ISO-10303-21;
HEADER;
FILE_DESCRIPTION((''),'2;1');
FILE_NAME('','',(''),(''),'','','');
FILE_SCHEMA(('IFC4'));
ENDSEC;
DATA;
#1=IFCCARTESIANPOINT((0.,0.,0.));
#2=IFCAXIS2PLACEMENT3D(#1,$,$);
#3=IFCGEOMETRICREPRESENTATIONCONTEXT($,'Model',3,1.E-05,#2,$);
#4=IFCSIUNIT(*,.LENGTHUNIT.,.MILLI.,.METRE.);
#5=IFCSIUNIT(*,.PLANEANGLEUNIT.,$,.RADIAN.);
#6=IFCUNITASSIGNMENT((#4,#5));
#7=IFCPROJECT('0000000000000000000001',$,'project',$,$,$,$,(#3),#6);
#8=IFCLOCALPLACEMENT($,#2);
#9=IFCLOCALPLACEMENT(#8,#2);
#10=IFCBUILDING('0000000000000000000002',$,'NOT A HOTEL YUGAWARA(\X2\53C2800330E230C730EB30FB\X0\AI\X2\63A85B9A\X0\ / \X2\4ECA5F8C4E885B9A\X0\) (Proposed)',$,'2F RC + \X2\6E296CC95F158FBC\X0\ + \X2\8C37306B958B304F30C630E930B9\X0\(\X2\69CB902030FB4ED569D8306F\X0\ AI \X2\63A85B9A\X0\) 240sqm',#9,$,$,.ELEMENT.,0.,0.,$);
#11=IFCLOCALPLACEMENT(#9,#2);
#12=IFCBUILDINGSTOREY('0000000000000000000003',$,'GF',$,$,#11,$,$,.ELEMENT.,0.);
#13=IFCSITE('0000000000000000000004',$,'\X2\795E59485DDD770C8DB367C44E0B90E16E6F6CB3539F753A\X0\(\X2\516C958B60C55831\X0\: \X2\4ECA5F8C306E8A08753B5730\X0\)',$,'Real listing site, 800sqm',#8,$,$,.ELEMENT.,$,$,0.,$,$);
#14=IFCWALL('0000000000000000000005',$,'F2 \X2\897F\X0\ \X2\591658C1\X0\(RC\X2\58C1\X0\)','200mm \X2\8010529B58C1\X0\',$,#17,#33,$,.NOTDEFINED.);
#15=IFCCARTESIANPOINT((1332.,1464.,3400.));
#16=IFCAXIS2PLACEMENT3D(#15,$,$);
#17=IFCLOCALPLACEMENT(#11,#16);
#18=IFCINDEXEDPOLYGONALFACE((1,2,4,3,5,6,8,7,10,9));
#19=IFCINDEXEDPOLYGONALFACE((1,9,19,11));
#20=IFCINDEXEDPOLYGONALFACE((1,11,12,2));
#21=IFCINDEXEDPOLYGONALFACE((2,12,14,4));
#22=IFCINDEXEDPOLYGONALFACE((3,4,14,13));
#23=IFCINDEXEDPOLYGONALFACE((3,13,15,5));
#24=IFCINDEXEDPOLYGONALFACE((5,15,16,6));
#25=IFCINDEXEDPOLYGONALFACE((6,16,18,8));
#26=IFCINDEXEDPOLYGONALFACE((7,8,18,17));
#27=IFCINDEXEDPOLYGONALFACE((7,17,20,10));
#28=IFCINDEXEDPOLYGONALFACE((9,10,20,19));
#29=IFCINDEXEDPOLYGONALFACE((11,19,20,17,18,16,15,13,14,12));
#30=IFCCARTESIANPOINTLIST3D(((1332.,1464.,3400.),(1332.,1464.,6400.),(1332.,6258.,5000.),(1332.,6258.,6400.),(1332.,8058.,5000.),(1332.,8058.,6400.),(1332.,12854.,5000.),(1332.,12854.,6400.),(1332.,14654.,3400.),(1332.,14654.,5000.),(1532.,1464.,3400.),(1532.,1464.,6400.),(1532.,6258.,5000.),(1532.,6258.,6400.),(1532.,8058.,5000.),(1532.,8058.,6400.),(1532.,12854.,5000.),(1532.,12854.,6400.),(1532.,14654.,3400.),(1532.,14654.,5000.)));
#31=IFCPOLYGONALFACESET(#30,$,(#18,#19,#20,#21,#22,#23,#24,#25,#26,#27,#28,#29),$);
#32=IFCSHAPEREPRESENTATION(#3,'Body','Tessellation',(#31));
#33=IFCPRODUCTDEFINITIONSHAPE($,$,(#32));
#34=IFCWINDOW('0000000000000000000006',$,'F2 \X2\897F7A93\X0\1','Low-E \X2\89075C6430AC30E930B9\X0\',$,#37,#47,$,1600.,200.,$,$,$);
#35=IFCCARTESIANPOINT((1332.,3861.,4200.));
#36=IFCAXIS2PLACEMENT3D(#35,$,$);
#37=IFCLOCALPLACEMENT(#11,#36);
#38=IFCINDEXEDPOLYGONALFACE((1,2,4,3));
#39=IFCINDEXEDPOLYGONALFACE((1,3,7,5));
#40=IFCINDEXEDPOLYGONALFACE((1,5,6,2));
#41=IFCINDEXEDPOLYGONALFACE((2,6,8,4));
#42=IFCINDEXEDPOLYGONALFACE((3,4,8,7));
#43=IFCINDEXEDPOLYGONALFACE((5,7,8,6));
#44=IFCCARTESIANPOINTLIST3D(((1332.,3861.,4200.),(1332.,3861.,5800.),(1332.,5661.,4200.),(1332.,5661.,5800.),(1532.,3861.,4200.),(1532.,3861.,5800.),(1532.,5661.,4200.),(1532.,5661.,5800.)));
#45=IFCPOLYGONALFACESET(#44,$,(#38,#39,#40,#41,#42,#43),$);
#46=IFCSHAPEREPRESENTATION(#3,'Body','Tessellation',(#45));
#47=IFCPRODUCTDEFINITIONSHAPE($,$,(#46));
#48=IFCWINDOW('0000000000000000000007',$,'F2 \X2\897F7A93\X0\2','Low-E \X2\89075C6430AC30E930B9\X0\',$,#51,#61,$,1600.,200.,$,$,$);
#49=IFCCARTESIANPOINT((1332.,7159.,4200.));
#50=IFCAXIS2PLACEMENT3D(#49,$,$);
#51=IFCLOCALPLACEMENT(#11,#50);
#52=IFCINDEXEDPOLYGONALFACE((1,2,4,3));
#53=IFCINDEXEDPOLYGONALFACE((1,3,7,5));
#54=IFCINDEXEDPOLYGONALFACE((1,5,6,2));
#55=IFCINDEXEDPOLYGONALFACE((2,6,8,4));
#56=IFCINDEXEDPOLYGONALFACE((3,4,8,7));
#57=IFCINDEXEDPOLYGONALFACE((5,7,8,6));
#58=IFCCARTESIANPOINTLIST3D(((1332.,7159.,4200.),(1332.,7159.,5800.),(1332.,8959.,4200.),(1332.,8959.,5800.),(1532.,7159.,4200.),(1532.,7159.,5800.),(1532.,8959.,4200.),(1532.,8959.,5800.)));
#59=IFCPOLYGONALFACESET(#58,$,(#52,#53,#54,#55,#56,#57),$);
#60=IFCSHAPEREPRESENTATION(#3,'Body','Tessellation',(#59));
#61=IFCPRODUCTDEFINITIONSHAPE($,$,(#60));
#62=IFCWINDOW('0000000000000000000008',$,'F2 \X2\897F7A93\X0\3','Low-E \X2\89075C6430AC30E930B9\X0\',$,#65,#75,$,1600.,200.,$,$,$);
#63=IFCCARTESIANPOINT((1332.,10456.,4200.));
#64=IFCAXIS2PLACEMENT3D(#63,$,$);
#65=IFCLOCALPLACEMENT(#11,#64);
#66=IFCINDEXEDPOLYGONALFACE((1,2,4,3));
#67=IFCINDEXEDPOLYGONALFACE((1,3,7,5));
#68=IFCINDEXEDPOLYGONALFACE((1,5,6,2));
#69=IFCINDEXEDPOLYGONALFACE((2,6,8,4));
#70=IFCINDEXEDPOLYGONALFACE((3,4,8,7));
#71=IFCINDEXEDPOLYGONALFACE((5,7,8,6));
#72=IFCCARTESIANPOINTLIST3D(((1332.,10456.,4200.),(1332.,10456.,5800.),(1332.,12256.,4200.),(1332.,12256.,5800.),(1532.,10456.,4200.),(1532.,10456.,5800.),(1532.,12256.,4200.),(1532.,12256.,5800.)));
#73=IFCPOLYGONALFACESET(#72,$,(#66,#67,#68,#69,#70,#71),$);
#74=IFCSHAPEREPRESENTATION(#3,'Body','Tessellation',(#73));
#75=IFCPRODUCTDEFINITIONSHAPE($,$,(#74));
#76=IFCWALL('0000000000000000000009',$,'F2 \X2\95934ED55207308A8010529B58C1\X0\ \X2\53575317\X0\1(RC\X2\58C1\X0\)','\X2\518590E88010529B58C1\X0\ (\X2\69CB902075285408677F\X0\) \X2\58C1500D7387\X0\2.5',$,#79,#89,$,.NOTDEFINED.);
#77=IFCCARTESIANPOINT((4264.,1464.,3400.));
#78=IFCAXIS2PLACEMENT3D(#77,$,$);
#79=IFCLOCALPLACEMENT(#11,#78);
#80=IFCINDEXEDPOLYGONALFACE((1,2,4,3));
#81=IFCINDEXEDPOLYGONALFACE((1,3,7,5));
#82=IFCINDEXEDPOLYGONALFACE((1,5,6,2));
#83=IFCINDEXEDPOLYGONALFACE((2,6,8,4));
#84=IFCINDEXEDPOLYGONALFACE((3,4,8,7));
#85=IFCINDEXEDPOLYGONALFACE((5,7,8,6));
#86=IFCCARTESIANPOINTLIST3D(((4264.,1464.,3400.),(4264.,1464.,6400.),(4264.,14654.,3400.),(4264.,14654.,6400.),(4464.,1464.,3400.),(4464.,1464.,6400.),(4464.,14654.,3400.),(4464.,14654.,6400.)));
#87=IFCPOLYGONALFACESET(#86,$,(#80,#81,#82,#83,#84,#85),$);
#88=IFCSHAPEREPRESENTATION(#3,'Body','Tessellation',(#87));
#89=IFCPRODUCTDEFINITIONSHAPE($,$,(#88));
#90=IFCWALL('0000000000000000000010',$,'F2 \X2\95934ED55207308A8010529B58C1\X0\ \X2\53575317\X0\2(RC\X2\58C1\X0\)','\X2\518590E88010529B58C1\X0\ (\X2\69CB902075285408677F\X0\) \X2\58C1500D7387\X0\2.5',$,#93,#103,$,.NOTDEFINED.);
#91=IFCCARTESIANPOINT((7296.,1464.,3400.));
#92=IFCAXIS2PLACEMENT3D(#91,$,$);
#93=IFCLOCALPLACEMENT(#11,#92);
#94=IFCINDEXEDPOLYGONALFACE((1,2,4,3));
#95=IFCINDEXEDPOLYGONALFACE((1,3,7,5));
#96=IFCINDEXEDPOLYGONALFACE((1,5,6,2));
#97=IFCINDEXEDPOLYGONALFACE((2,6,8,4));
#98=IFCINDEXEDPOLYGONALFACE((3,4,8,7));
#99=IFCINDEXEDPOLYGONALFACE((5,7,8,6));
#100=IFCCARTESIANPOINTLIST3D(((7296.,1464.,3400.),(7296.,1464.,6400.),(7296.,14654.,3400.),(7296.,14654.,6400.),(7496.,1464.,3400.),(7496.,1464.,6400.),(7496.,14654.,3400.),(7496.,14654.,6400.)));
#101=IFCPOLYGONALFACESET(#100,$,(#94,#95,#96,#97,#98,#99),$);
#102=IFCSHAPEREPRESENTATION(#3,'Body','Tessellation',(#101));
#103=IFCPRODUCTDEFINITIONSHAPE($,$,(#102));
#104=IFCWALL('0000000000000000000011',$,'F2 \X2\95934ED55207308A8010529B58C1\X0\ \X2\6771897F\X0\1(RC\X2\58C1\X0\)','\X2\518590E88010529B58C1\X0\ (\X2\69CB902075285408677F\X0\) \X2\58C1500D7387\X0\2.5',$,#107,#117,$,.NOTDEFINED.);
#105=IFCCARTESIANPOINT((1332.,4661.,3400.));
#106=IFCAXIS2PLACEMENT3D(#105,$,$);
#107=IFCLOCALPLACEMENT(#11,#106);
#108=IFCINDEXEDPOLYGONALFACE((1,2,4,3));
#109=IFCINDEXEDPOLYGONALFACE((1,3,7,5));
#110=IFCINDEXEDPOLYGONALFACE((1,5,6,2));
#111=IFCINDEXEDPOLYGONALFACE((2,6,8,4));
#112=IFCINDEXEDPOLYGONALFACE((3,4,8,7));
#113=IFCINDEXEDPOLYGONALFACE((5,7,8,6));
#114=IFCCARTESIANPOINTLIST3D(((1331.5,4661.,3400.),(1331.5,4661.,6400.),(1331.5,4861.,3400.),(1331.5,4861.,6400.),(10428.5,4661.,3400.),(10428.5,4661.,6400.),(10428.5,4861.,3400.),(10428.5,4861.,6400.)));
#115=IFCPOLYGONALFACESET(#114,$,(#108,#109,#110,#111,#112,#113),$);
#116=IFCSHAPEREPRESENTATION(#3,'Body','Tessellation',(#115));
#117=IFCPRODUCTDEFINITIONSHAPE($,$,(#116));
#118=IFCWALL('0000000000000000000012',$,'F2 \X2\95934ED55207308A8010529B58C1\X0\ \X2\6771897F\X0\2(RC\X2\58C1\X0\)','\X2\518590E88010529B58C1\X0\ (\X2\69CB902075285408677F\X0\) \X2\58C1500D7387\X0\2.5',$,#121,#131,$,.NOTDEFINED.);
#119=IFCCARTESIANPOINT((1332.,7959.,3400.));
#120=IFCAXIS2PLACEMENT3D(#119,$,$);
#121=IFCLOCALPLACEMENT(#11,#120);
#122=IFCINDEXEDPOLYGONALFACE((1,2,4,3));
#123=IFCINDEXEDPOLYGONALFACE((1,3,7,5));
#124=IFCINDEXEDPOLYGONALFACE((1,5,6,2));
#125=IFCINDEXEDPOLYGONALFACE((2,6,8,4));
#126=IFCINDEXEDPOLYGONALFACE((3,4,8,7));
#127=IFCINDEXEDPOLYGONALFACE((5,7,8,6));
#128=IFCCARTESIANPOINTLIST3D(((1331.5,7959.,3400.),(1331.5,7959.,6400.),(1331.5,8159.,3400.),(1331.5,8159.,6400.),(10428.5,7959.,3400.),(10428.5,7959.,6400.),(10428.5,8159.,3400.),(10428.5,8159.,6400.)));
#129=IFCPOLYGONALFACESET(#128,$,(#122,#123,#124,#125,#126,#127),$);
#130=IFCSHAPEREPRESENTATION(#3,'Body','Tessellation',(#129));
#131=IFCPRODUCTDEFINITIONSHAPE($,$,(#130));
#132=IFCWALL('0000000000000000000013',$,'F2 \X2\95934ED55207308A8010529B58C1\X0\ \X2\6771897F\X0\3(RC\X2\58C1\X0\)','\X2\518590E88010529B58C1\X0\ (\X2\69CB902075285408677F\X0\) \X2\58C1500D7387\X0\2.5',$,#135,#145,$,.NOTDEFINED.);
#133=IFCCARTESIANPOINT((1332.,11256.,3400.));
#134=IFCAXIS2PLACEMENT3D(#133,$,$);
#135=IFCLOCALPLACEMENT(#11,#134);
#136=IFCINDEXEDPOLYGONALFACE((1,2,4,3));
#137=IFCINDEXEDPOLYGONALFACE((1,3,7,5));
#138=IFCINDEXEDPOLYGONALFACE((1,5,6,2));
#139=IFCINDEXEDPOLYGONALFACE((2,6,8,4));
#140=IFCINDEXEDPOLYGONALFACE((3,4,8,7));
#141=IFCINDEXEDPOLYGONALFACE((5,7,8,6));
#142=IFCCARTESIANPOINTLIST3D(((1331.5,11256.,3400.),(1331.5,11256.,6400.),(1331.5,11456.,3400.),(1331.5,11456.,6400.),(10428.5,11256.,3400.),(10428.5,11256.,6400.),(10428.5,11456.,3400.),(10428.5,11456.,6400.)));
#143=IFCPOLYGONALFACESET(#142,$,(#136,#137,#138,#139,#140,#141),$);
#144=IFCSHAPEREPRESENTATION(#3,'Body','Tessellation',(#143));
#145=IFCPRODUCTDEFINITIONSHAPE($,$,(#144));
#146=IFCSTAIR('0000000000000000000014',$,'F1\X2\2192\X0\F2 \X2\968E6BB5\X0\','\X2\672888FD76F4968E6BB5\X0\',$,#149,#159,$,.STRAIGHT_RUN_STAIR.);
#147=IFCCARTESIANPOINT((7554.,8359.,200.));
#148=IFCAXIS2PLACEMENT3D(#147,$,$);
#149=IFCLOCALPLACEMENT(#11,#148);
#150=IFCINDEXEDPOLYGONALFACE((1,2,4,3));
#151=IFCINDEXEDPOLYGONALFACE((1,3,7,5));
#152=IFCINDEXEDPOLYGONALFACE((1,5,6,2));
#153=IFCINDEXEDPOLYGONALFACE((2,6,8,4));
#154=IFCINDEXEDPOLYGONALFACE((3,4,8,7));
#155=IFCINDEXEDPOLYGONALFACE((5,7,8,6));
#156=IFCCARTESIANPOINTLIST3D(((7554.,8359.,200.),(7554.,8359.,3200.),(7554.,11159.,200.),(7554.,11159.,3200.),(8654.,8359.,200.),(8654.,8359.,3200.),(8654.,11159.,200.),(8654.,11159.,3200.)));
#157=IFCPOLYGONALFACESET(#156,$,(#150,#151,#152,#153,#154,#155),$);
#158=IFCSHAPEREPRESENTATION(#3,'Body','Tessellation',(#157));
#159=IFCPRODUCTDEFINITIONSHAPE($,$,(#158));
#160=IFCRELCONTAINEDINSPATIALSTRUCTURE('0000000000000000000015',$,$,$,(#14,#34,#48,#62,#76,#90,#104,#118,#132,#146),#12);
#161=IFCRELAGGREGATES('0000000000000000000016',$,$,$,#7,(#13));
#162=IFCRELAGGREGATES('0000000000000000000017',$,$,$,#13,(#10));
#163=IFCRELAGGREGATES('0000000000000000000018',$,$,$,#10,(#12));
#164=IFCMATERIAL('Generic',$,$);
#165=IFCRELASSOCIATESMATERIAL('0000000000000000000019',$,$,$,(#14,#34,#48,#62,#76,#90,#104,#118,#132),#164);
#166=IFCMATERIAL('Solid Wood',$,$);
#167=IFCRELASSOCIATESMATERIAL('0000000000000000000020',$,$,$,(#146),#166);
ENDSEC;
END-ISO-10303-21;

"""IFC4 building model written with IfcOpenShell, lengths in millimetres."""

from ifc_helpers import new_model, si_unit, frame, frame_2d, origin, place, context, project, spatial, rectangle, extrude, material, element, fill, save


model = new_model("IFC4")

# Units and contexts
model_context = context("Model", 3, precision=1e-05, world=origin())
ifc_project = project(units=[si_unit("LENGTHUNIT", "METRE", prefix="MILLI"), si_unit("PLANEANGLEUNIT", "RADIAN")], contexts=[model_context])

# Site, building, storey
site_placement = place(None, origin())
site = spatial("IfcSite", under=ifc_project, at=site_placement, Name="神奈川県足柄下郡湯河原町(公開情報: 今後の計画地)", ObjectType="Real listing site, 800sqm", CompositionType="ELEMENT", RefElevation=0.0)
building_placement = place(site_placement, origin())
building = spatial("IfcBuilding", under=site, at=building_placement, Name="NOT A HOTEL YUGAWARA(参考モデル・AI推定 / 今後予定) (Proposed)", ObjectType="2F RC + 温泉引込 + 谷に開くテラス(構造・仕様は AI 推定) 240sqm", CompositionType="ELEMENT", ElevationOfRefHeight=0.0, ElevationOfTerrain=0.0)
storey_placement = place(building_placement, origin())
storey = spatial("IfcBuildingStorey", under=building, at=storey_placement, Name="GF", CompositionType="ELEMENT", Elevation=0.0)

# Shared definitions
ifc_material_1 = material(Name="Generic")

# Wall, openings, windows
wall_1_placement = place(storey_placement, frame((1332.0, 1464.0, 3400.0)))
wall_1 = element("IfcWall", 1, at=wall_1_placement, inside=storey, material=ifc_material_1, Name="F2 西 外壁(RC壁)", Description="200mm 耐力壁", PredefinedType="NOTDEFINED", context=model_context, shape_type="SweptSolid", body=[
    extrude(rectangle(XDim=200.0, YDim=13190.0, at=frame_2d((100.0, 6595.0))), frame((1332.0, 1464.0, 3400.0)), (0.0, 0.0, 1.0), 3000.0),
])
opening_1_placement = place(storey_placement, frame((1332.0, 3861.0, 4200.0)))
opening_1 = element("IfcOpeningElement", 2, at=opening_1_placement, cuts=wall_1, PredefinedType="NOTDEFINED", context=model_context, shape_type="SweptSolid", body=[
    extrude(rectangle(XDim=200.0, YDim=1800.0, at=frame_2d((100.0, 900.0))), frame((1332.0, 3861.0, 4200.0)), (0.0, 0.0, 1.0), 1600.0),
])
opening_2_placement = place(storey_placement, frame((1332.0, 7159.0, 4200.0)))
opening_2 = element("IfcOpeningElement", 3, at=opening_2_placement, cuts=wall_1, PredefinedType="NOTDEFINED", context=model_context, shape_type="SweptSolid", body=[
    extrude(rectangle(XDim=200.0, YDim=1800.0, at=frame_2d((100.0, 900.0))), frame((1332.0, 7159.0, 4200.0)), (0.0, 0.0, 1.0), 1600.0),
])
opening_3_placement = place(storey_placement, frame((1332.0, 10456.0, 4200.0)))
opening_3 = element("IfcOpeningElement", 4, at=opening_3_placement, cuts=wall_1, PredefinedType="NOTDEFINED", context=model_context, shape_type="SweptSolid", body=[
    extrude(rectangle(XDim=200.0, YDim=1800.0, at=frame_2d((100.0, 900.0))), frame((1332.0, 10456.0, 4200.0)), (0.0, 0.0, 1.0), 1600.0),
])
window_1_placement = place(storey_placement, frame((1332.0, 3861.0, 4200.0)))
window_1 = element("IfcWindow", 5, at=window_1_placement, inside=storey, material=ifc_material_1, Name="F2 西窓1", Description="Low-E 複層ガラス", OverallHeight=1600.0, OverallWidth=200.0, context=model_context, shape_type="SweptSolid", body=[
    extrude(rectangle(XDim=200.0, YDim=1800.0, at=frame_2d((100.0, 900.0))), frame((1332.0, 3861.0, 4200.0)), (0.0, 0.0, 1.0), 1600.0),
])
fill(opening_1, window_1)
window_2_placement = place(storey_placement, frame((1332.0, 7159.0, 4200.0)))
window_2 = element("IfcWindow", 6, at=window_2_placement, inside=storey, material=ifc_material_1, Name="F2 西窓2", Description="Low-E 複層ガラス", OverallHeight=1600.0, OverallWidth=200.0, context=model_context, shape_type="SweptSolid", body=[
    extrude(rectangle(XDim=200.0, YDim=1800.0, at=frame_2d((100.0, 900.0))), frame((1332.0, 7159.0, 4200.0)), (0.0, 0.0, 1.0), 1600.0),
])
fill(opening_2, window_2)
window_3_placement = place(storey_placement, frame((1332.0, 10456.0, 4200.0)))
window_3 = element("IfcWindow", 7, at=window_3_placement, inside=storey, material=ifc_material_1, Name="F2 西窓3", Description="Low-E 複層ガラス", OverallHeight=1600.0, OverallWidth=200.0, context=model_context, shape_type="SweptSolid", body=[
    extrude(rectangle(XDim=200.0, YDim=1800.0, at=frame_2d((100.0, 900.0))), frame((1332.0, 10456.0, 4200.0)), (0.0, 0.0, 1.0), 1600.0),
])
fill(opening_3, window_3)

# Walls
wall_2_placement = place(storey_placement, frame((4264.0, 1464.0, 3400.0)))
element("IfcWall", 8, at=wall_2_placement, inside=storey, material=ifc_material_1, Name="F2 間仕切り耐力壁 南北1(RC壁)", Description="内部耐力壁 (構造用合板) 壁倍率2.5", PredefinedType="NOTDEFINED", context=model_context, shape_type="SweptSolid", body=[
    extrude(rectangle(XDim=200.0, YDim=13190.0, at=frame_2d((100.0, 6595.0))), frame((4264.0, 1464.0, 3400.0)), (0.0, 0.0, 1.0), 3000.0),
])
wall_3_placement = place(storey_placement, frame((7296.0, 1464.0, 3400.0)))
element("IfcWall", 9, at=wall_3_placement, inside=storey, material=ifc_material_1, Name="F2 間仕切り耐力壁 南北2(RC壁)", Description="内部耐力壁 (構造用合板) 壁倍率2.5", PredefinedType="NOTDEFINED", context=model_context, shape_type="SweptSolid", body=[
    extrude(rectangle(XDim=200.0, YDim=13190.0, at=frame_2d((100.0, 6595.0))), frame((7296.0, 1464.0, 3400.0)), (0.0, 0.0, 1.0), 3000.0),
])
wall_4_placement = place(storey_placement, frame((1332.0, 4661.0, 3400.0)))
element("IfcWall", 10, at=wall_4_placement, inside=storey, material=ifc_material_1, Name="F2 間仕切り耐力壁 東西1(RC壁)", Description="内部耐力壁 (構造用合板) 壁倍率2.5", PredefinedType="NOTDEFINED", context=model_context, shape_type="SweptSolid", body=[
    extrude(rectangle(XDim=9097.0, YDim=200.0, at=frame_2d((4548.0, 100.0))), frame((1332.0, 4661.0, 3400.0)), (0.0, 0.0, 1.0), 3000.0),
])
wall_5_placement = place(storey_placement, frame((1332.0, 7959.0, 3400.0)))
element("IfcWall", 11, at=wall_5_placement, inside=storey, material=ifc_material_1, Name="F2 間仕切り耐力壁 東西2(RC壁)", Description="内部耐力壁 (構造用合板) 壁倍率2.5", PredefinedType="NOTDEFINED", context=model_context, shape_type="SweptSolid", body=[
    extrude(rectangle(XDim=9097.0, YDim=200.0, at=frame_2d((4548.0, 100.0))), frame((1332.0, 7959.0, 3400.0)), (0.0, 0.0, 1.0), 3000.0),
])
wall_6_placement = place(storey_placement, frame((1332.0, 11256.0, 3400.0)))
element("IfcWall", 12, at=wall_6_placement, inside=storey, material=ifc_material_1, Name="F2 間仕切り耐力壁 東西3(RC壁)", Description="内部耐力壁 (構造用合板) 壁倍率2.5", PredefinedType="NOTDEFINED", context=model_context, shape_type="SweptSolid", body=[
    extrude(rectangle(XDim=9097.0, YDim=200.0, at=frame_2d((4548.0, 100.0))), frame((1332.0, 11256.0, 3400.0)), (0.0, 0.0, 1.0), 3000.0),
])

# Stair
ifc_material_2 = material(Name="Solid Wood")
stair_placement = place(storey_placement, frame((7554.0, 8359.0, 200.0)))
element("IfcStair", 13, at=stair_placement, inside=storey, material=ifc_material_2, Name="F1→F2 階段", Description="木製直階段", PredefinedType="STRAIGHT_RUN_STAIR", context=model_context, shape_type="SweptSolid", body=[
    extrude(rectangle(XDim=1100.0, YDim=2800.0, at=frame_2d((550.0, 1400.0))), frame((7554.0, 8359.0, 200.0)), (0.0, 0.0, 1.0), 3000.0),
])

save(model, "model.ifc")
